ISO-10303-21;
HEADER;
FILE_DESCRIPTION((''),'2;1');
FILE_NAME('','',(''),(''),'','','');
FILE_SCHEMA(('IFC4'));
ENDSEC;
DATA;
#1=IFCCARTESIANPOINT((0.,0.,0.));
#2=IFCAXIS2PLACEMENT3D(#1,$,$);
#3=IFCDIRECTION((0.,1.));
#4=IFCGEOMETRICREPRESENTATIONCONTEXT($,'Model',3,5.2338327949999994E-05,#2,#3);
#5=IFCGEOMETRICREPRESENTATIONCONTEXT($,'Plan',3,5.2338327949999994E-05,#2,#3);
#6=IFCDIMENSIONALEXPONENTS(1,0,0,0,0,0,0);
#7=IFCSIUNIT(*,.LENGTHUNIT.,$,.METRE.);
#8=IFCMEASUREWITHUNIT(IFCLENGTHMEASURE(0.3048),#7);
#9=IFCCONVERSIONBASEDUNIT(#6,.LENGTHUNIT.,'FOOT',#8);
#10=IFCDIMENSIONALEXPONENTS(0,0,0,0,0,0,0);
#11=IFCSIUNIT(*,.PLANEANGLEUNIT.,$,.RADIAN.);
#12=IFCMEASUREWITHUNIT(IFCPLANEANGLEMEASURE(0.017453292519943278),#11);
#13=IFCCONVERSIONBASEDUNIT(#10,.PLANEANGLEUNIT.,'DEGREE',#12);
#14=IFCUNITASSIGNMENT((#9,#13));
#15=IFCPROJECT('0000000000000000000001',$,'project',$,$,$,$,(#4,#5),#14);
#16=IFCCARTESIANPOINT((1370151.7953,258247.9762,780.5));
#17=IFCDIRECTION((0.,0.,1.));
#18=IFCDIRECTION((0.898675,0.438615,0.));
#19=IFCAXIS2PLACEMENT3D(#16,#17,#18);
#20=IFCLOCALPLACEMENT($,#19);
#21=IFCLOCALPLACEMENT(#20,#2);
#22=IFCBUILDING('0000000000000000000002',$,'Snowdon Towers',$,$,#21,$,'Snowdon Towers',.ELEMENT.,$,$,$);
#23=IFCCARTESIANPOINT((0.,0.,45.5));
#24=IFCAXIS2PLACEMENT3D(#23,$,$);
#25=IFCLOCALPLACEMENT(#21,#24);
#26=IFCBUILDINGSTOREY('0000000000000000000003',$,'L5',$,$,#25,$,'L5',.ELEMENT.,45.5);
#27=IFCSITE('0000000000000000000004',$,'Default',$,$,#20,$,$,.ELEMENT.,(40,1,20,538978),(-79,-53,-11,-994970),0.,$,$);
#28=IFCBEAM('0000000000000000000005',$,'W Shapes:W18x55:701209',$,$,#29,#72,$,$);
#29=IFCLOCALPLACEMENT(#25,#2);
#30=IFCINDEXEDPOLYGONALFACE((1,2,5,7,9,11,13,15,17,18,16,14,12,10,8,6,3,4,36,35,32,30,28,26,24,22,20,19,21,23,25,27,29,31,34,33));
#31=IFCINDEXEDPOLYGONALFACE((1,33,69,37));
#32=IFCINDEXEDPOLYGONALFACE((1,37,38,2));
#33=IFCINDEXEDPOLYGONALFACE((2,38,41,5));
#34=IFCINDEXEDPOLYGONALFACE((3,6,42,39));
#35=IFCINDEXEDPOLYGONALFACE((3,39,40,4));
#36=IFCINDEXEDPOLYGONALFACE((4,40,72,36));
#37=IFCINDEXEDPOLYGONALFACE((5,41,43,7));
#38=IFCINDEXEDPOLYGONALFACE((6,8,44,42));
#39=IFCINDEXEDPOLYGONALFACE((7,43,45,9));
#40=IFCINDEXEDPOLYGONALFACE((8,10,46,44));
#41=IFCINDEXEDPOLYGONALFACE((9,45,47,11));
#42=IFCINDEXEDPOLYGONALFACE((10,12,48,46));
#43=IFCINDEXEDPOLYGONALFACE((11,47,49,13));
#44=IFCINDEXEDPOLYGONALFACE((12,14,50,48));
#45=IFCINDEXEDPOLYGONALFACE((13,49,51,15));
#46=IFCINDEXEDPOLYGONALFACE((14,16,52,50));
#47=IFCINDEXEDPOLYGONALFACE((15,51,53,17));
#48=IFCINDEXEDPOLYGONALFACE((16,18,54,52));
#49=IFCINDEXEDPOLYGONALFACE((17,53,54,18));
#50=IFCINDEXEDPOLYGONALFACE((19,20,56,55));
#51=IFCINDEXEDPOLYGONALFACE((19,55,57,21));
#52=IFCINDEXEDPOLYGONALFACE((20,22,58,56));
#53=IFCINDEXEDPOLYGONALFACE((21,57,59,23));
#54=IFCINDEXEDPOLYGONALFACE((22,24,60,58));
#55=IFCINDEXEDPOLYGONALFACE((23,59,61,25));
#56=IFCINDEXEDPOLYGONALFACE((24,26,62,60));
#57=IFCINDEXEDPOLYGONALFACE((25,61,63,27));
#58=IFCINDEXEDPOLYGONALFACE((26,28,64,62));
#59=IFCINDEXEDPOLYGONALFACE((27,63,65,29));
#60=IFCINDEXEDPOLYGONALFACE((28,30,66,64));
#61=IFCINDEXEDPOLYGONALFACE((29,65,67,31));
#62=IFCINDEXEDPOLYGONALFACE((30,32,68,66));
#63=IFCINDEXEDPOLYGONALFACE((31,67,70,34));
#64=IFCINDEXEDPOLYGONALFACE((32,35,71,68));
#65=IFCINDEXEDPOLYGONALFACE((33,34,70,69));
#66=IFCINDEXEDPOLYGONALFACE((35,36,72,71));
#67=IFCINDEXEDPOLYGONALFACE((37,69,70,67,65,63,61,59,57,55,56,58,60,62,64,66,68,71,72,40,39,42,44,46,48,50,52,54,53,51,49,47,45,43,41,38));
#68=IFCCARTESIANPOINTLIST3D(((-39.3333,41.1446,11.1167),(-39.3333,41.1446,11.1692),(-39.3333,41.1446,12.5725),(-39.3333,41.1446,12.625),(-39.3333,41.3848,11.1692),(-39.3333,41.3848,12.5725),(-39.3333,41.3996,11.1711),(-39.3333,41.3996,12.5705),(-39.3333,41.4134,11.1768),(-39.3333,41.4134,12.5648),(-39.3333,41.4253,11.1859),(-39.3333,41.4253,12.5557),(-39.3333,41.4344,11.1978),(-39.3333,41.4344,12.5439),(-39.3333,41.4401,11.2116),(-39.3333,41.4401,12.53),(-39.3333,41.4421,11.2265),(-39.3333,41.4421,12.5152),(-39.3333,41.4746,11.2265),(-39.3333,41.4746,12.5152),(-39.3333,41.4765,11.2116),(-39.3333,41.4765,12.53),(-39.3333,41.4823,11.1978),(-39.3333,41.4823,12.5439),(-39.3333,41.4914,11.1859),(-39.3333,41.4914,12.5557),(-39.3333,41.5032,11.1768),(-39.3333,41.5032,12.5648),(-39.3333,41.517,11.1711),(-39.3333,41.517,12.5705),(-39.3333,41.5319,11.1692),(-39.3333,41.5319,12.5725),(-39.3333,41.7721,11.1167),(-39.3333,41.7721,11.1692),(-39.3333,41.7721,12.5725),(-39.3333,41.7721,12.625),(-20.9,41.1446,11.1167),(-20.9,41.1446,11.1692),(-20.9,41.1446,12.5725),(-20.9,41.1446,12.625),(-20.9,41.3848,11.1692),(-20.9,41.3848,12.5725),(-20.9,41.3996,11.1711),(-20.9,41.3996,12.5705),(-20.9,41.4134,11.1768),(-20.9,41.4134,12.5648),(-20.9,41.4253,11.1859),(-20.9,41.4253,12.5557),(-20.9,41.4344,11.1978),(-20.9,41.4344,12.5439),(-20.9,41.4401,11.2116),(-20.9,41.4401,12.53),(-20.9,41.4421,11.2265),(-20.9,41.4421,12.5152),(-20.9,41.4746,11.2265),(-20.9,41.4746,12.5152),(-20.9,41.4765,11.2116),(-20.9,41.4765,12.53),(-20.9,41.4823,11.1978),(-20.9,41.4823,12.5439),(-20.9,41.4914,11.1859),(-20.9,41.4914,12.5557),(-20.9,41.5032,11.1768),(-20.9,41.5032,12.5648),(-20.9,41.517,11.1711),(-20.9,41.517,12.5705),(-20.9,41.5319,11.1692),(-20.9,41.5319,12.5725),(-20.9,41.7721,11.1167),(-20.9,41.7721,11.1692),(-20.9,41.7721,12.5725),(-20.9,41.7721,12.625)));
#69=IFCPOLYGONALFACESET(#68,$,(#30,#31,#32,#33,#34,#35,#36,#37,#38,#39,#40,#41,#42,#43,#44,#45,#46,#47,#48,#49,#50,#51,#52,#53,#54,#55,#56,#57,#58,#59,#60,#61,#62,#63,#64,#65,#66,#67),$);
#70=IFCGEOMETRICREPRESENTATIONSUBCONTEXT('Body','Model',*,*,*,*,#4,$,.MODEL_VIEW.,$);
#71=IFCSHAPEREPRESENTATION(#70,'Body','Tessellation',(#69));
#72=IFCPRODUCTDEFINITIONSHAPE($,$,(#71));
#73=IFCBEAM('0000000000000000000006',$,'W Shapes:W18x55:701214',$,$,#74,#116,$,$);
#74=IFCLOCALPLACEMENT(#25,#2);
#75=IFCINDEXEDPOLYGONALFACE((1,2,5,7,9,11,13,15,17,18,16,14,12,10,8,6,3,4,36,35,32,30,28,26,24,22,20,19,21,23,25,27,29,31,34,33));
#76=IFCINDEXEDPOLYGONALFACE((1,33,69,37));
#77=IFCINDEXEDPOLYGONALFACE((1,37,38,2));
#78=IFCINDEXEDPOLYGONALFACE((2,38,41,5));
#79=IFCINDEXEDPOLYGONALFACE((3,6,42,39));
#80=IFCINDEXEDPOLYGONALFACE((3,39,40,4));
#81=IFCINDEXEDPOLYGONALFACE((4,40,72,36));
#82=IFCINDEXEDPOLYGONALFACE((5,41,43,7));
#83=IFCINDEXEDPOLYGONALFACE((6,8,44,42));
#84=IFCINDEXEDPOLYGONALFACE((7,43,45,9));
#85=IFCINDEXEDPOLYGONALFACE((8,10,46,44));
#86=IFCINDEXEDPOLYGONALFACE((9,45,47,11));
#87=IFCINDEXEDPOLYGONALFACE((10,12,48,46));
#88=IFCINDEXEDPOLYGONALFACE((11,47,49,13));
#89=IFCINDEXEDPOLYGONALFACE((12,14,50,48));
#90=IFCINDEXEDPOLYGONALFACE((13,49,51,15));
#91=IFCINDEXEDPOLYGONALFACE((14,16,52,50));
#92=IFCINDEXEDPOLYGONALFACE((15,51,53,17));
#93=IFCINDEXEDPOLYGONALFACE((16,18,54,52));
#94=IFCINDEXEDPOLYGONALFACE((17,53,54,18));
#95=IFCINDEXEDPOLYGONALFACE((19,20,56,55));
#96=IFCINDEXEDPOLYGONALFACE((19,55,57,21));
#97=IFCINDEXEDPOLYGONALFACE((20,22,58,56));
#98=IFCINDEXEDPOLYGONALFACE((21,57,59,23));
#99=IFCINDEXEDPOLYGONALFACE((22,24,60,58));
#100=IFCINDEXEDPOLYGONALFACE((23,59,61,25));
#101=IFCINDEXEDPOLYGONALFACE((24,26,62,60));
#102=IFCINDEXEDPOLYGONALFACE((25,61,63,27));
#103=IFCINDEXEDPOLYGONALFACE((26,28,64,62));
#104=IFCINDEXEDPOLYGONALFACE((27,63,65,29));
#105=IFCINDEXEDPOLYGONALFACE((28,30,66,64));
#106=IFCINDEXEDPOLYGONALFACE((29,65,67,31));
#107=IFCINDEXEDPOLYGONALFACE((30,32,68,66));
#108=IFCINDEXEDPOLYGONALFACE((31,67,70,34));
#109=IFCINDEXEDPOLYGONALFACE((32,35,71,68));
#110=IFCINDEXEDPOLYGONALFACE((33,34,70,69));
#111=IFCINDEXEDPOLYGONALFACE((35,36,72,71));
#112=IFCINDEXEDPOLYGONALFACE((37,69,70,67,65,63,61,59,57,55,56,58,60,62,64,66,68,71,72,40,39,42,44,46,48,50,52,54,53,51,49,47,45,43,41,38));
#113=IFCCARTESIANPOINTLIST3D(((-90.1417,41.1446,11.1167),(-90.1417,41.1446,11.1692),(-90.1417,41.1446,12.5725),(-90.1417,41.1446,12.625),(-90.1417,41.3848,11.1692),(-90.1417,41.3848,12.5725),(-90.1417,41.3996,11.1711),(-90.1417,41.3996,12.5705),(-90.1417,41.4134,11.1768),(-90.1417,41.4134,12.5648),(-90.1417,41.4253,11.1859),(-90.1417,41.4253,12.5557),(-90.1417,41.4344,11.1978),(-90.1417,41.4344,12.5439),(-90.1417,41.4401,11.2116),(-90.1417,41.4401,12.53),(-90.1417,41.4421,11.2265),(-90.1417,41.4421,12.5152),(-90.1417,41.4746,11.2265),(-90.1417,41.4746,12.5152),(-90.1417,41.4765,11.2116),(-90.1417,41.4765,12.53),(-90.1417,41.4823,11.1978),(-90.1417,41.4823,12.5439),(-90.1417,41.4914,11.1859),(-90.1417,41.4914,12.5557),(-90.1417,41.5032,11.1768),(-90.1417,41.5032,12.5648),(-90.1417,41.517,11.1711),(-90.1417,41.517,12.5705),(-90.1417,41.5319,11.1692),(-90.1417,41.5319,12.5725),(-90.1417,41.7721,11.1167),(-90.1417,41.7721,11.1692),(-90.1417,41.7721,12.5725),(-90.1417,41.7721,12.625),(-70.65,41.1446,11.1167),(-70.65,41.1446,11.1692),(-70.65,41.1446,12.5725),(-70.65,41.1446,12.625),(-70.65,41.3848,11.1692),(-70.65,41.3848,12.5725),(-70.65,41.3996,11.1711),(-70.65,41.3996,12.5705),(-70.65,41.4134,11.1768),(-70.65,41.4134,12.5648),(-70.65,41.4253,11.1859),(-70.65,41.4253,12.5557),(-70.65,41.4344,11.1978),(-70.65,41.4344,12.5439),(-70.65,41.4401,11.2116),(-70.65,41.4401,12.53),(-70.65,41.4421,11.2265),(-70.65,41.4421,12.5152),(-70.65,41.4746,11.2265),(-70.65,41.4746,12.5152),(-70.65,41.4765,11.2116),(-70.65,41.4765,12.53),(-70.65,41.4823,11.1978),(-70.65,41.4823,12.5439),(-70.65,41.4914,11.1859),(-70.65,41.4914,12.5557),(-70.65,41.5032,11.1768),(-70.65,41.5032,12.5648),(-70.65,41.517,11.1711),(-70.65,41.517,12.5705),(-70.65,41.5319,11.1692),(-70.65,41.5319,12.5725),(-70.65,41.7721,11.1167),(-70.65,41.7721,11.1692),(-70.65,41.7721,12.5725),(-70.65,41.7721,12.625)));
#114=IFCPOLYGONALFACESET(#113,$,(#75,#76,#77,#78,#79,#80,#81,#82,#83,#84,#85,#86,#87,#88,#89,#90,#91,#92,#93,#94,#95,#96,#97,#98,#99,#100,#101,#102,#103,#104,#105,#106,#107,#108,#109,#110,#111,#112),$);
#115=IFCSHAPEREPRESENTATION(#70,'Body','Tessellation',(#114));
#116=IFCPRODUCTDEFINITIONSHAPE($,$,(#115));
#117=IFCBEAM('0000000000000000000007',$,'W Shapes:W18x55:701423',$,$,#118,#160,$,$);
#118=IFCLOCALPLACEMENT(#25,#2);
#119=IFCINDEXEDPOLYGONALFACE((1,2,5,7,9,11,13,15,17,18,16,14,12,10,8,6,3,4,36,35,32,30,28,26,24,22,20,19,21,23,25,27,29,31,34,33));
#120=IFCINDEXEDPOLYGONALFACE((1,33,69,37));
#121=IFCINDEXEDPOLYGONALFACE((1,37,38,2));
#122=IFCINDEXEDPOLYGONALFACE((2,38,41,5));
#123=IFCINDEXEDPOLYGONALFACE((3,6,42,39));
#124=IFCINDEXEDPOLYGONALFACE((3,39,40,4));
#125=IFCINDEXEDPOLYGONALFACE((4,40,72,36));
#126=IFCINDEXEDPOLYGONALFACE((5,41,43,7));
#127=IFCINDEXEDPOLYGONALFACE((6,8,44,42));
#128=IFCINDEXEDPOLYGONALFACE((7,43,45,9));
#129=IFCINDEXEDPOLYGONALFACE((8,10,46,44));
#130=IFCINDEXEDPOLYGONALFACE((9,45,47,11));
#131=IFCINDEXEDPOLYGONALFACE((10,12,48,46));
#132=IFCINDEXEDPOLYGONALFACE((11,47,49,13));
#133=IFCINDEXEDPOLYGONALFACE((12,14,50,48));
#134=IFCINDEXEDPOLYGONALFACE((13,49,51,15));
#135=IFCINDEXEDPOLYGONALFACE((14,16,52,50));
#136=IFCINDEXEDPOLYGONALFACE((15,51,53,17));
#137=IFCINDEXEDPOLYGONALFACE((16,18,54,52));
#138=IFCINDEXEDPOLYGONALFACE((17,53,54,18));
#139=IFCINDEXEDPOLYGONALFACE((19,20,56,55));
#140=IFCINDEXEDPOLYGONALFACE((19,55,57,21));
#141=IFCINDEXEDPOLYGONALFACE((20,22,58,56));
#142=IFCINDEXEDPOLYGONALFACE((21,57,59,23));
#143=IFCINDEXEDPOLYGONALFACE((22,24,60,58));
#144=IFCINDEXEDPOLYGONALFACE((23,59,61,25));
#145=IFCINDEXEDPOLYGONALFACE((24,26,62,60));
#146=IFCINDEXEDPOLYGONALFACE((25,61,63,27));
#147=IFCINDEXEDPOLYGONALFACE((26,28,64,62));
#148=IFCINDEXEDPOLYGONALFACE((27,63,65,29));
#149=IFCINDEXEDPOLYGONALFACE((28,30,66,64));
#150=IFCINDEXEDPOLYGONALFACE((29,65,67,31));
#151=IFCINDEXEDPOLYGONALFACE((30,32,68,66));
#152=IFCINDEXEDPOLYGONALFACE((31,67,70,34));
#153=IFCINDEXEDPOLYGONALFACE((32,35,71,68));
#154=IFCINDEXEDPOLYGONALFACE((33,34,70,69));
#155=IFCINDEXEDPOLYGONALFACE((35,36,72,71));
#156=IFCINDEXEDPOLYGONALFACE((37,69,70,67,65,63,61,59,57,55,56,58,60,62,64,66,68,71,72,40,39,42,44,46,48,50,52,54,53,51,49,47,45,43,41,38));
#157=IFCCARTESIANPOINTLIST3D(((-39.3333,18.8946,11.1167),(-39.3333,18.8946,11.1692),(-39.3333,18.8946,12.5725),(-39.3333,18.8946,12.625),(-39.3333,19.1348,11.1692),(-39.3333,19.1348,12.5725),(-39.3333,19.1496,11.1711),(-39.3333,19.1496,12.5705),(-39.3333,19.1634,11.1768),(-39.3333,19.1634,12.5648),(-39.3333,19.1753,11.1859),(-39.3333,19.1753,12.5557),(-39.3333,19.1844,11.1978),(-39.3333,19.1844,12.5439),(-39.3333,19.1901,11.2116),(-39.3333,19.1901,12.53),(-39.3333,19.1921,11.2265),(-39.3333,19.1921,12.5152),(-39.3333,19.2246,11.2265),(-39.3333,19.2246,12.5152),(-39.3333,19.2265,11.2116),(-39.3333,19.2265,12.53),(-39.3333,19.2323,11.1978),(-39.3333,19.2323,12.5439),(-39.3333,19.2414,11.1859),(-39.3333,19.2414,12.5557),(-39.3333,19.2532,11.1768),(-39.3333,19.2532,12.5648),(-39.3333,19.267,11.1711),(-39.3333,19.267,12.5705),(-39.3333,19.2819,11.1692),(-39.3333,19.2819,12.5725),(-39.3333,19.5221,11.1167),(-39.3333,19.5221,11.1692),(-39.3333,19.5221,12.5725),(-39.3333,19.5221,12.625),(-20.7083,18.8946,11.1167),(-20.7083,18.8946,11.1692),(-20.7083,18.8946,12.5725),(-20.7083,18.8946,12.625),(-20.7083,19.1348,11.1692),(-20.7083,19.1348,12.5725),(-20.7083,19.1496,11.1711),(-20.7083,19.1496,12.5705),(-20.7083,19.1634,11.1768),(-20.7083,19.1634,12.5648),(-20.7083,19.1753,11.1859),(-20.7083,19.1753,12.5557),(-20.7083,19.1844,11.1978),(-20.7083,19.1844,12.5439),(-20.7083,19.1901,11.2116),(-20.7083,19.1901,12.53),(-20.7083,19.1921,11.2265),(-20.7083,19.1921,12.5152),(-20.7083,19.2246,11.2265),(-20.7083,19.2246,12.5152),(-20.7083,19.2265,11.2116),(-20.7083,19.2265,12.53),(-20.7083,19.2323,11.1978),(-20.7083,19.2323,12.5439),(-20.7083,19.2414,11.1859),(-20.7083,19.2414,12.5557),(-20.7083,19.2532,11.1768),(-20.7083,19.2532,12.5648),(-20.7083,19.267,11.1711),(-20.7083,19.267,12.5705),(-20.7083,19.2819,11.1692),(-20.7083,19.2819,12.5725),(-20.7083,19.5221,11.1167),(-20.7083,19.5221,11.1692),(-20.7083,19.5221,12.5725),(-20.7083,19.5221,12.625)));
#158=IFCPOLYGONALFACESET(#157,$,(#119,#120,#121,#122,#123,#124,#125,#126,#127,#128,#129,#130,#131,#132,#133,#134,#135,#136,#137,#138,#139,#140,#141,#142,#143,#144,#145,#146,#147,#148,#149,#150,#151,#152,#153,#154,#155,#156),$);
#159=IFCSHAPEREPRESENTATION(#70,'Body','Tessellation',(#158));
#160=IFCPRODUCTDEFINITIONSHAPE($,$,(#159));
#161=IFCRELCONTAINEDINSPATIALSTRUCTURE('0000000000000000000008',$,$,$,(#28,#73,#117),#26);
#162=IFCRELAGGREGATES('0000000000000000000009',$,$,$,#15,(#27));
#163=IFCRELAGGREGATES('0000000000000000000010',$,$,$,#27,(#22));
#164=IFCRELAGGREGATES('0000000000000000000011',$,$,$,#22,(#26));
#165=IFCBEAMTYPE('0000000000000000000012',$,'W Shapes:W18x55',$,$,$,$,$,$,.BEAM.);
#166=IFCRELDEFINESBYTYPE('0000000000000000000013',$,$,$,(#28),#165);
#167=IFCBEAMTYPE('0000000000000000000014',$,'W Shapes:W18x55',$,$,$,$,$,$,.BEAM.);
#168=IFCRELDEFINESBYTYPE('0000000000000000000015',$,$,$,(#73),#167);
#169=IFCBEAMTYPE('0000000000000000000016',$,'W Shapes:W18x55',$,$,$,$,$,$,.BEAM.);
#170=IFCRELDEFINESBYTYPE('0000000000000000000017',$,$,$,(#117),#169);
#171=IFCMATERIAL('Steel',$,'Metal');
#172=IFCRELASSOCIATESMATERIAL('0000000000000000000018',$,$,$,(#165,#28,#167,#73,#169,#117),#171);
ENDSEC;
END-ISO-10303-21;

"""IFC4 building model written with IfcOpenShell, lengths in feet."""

from ifc_helpers import new_model, entity, si_unit, converted_unit, direction, frame, origin, place, context, subcontext, project, spatial, line, arc, indexed_curve, outline, extrude, source, transform, mapped, material, type_object, type_shapes, element, save


model = new_model("IFC4")

# Units and contexts
model_context = context("Model", 3, precision=5.2338327949999994e-05, world=origin(), true_north=direction((0.0, 1.0)))
plan_context = context("Plan", 3, precision=5.2338327949999994e-05, world=origin(), true_north=direction((0.0, 1.0)))
body_context = subcontext(model_context, "Body", "Model", "MODEL_VIEW")
ifc_project = project(units=[converted_unit("LENGTHUNIT", "FOOT", entity("IfcLengthMeasure", 0.3048), si_unit("LENGTHUNIT", "METRE"), dimensions=[1, 0, 0, 0, 0, 0, 0]), converted_unit("PLANEANGLEUNIT", "DEGREE", entity("IfcPlaneAngleMeasure", 0.017453292519943278), si_unit("PLANEANGLEUNIT", "RADIAN"), dimensions=[0, 0, 0, 0, 0, 0, 0])], contexts=[model_context, plan_context])

# Site, building, storey
site_placement = place(None, frame((1370151.7953, 258247.9762, 780.5), z_axis=(0.0, 0.0, 1.0), x_axis=(0.898675, 0.438615, 0.0)))
site = spatial("IfcSite", under=ifc_project, at=site_placement, Name="Default", CompositionType="ELEMENT", RefLatitude=(40, 1, 20, 538978), RefLongitude=(-79, -53, -11, -994970), RefElevation=0.0)
building_placement = place(site_placement, origin())
building = spatial("IfcBuilding", under=site, at=building_placement, Name="Snowdon Towers", LongName="Snowdon Towers", CompositionType="ELEMENT")
storey_placement = place(building_placement, frame((0.0, 0.0, 45.5)))
storey = spatial("IfcBuildingStorey", under=building, at=storey_placement, Name="L5", LongName="L5", CompositionType="ELEMENT", Elevation=45.5)

# Beams
ifc_material_1 = material(Name="Steel", Category="Metal")
beam_type_1 = type_object("IfcBeamType", Name="W Shapes:W18x55", PredefinedType="BEAM", material=ifc_material_1)
shared_shape_1 = source(origin(), body_context, "Body", "SweptSolid", [
    extrude(outline(indexed_curve([(-0.7542, -0.3138), (-0.7017, -0.3138), (-0.7017, -0.0735), (-0.6849, -0.033), (-0.6444, -0.0162), (0.6444, -0.0162), (0.6849, -0.033), (0.7017, -0.0735), (0.7017, -0.3138), (0.7542, -0.3138), (0.7542, 0.3138), (0.7017, 0.3138), (0.7017, 0.0735), (0.6849, 0.033), (0.6444, 0.0163), (-0.6444, 0.0163), (-0.6849, 0.033), (-0.7017, 0.0735), (-0.7017, 0.3137), (-0.7542, 0.3137)], segments=[line(1, 2, 3), arc(3, 4, 5), line(5, 6), arc(6, 7, 8), line(8, 9, 10, 11, 12, 13), arc(13, 14, 15), line(15, 16), arc(16, 17, 18), line(18, 19, 20, 1)], self_intersect=False)), frame((-9.2708, 0.0, 0.0), z_axis=(1.0, 0.0, 0.0), x_axis=(0.0, 0.0, -1.0)), (0.0, 0.0, 1.0), 18.4333),
])
type_shapes(beam_type_1, [shared_shape_1])
beam_1_placement = place(storey_placement, frame((-30.0625, 41.4583, 11.8708)))
element("IfcBeam", 1, at=beam_1_placement, inside=storey, type_object=beam_type_1, material=ifc_material_1, Name="W Shapes:W18x55:701209", context=body_context, shape_type="MappedRepresentation", body=[
    mapped(shared_shape_1, transform((0.0, 0.0, 0.0), scale=1.0)),
])
beam_type_2 = type_object("IfcBeamType", Name="W Shapes:W18x55", PredefinedType="BEAM", material=ifc_material_1)
shared_shape_2 = source(origin(), body_context, "Body", "SweptSolid", [
    extrude(outline(indexed_curve([(-0.7542, -0.3138), (-0.7017, -0.3138), (-0.7017, -0.0735), (-0.6849, -0.033), (-0.6444, -0.0162), (0.6444, -0.0162), (0.6849, -0.033), (0.7017, -0.0735), (0.7017, -0.3138), (0.7542, -0.3138), (0.7542, 0.3138), (0.7017, 0.3138), (0.7017, 0.0735), (0.6849, 0.033), (0.6444, 0.0163), (-0.6444, 0.0163), (-0.6849, 0.033), (-0.7017, 0.0735), (-0.7017, 0.3137), (-0.7542, 0.3137)], segments=[line(1, 2, 3), arc(3, 4, 5), line(5, 6), arc(6, 7, 8), line(8, 9, 10, 11, 12, 13), arc(13, 14, 15), line(15, 16), arc(16, 17, 18), line(18, 19, 20, 1)], self_intersect=False)), frame((-9.7875, 0.0, 0.0), z_axis=(1.0, 0.0, 0.0), x_axis=(0.0, 0.0, -1.0)), (0.0, 0.0, 1.0), 19.4917),
])
type_shapes(beam_type_2, [shared_shape_2])
beam_2_placement = place(storey_placement, frame((-80.3542, 41.4583, 11.8708)))
element("IfcBeam", 2, at=beam_2_placement, inside=storey, type_object=beam_type_2, material=ifc_material_1, Name="W Shapes:W18x55:701214", context=body_context, shape_type="MappedRepresentation", body=[
    mapped(shared_shape_2, transform((0.0, 0.0, 0.0), scale=1.0)),
])
beam_type_3 = type_object("IfcBeamType", Name="W Shapes:W18x55", PredefinedType="BEAM", material=ifc_material_1)
shared_shape_3 = source(origin(), body_context, "Body", "SweptSolid", [
    extrude(outline(indexed_curve([(-0.7542, -0.3138), (-0.7017, -0.3138), (-0.7017, -0.0735), (-0.6849, -0.033), (-0.6444, -0.0162), (0.6444, -0.0162), (0.6849, -0.033), (0.7017, -0.0735), (0.7017, -0.3138), (0.7542, -0.3138), (0.7542, 0.3138), (0.7017, 0.3138), (0.7017, 0.0735), (0.6849, 0.033), (0.6444, 0.0163), (-0.6444, 0.0163), (-0.6849, 0.033), (-0.7017, 0.0735), (-0.7017, 0.3137), (-0.7542, 0.3137)], segments=[line(1, 2, 3), arc(3, 4, 5), line(5, 6), arc(6, 7, 8), line(8, 9, 10, 11, 12, 13), arc(13, 14, 15), line(15, 16), arc(16, 17, 18), line(18, 19, 20, 1)], self_intersect=False)), frame((-9.2708, 0.0, 0.0), z_axis=(1.0, 0.0, 0.0), x_axis=(0.0, 0.0, -1.0)), (0.0, 0.0, 1.0), 18.625),
])
type_shapes(beam_type_3, [shared_shape_3])
beam_3_placement = place(storey_placement, frame((-30.0625, 19.2083, 11.8708)))
element("IfcBeam", 3, at=beam_3_placement, inside=storey, type_object=beam_type_3, material=ifc_material_1, Name="W Shapes:W18x55:701423", context=body_context, shape_type="MappedRepresentation", body=[
    mapped(shared_shape_3, transform((0.0, 0.0, 0.0), scale=1.0)),
])

save(model, "model.ifc")
